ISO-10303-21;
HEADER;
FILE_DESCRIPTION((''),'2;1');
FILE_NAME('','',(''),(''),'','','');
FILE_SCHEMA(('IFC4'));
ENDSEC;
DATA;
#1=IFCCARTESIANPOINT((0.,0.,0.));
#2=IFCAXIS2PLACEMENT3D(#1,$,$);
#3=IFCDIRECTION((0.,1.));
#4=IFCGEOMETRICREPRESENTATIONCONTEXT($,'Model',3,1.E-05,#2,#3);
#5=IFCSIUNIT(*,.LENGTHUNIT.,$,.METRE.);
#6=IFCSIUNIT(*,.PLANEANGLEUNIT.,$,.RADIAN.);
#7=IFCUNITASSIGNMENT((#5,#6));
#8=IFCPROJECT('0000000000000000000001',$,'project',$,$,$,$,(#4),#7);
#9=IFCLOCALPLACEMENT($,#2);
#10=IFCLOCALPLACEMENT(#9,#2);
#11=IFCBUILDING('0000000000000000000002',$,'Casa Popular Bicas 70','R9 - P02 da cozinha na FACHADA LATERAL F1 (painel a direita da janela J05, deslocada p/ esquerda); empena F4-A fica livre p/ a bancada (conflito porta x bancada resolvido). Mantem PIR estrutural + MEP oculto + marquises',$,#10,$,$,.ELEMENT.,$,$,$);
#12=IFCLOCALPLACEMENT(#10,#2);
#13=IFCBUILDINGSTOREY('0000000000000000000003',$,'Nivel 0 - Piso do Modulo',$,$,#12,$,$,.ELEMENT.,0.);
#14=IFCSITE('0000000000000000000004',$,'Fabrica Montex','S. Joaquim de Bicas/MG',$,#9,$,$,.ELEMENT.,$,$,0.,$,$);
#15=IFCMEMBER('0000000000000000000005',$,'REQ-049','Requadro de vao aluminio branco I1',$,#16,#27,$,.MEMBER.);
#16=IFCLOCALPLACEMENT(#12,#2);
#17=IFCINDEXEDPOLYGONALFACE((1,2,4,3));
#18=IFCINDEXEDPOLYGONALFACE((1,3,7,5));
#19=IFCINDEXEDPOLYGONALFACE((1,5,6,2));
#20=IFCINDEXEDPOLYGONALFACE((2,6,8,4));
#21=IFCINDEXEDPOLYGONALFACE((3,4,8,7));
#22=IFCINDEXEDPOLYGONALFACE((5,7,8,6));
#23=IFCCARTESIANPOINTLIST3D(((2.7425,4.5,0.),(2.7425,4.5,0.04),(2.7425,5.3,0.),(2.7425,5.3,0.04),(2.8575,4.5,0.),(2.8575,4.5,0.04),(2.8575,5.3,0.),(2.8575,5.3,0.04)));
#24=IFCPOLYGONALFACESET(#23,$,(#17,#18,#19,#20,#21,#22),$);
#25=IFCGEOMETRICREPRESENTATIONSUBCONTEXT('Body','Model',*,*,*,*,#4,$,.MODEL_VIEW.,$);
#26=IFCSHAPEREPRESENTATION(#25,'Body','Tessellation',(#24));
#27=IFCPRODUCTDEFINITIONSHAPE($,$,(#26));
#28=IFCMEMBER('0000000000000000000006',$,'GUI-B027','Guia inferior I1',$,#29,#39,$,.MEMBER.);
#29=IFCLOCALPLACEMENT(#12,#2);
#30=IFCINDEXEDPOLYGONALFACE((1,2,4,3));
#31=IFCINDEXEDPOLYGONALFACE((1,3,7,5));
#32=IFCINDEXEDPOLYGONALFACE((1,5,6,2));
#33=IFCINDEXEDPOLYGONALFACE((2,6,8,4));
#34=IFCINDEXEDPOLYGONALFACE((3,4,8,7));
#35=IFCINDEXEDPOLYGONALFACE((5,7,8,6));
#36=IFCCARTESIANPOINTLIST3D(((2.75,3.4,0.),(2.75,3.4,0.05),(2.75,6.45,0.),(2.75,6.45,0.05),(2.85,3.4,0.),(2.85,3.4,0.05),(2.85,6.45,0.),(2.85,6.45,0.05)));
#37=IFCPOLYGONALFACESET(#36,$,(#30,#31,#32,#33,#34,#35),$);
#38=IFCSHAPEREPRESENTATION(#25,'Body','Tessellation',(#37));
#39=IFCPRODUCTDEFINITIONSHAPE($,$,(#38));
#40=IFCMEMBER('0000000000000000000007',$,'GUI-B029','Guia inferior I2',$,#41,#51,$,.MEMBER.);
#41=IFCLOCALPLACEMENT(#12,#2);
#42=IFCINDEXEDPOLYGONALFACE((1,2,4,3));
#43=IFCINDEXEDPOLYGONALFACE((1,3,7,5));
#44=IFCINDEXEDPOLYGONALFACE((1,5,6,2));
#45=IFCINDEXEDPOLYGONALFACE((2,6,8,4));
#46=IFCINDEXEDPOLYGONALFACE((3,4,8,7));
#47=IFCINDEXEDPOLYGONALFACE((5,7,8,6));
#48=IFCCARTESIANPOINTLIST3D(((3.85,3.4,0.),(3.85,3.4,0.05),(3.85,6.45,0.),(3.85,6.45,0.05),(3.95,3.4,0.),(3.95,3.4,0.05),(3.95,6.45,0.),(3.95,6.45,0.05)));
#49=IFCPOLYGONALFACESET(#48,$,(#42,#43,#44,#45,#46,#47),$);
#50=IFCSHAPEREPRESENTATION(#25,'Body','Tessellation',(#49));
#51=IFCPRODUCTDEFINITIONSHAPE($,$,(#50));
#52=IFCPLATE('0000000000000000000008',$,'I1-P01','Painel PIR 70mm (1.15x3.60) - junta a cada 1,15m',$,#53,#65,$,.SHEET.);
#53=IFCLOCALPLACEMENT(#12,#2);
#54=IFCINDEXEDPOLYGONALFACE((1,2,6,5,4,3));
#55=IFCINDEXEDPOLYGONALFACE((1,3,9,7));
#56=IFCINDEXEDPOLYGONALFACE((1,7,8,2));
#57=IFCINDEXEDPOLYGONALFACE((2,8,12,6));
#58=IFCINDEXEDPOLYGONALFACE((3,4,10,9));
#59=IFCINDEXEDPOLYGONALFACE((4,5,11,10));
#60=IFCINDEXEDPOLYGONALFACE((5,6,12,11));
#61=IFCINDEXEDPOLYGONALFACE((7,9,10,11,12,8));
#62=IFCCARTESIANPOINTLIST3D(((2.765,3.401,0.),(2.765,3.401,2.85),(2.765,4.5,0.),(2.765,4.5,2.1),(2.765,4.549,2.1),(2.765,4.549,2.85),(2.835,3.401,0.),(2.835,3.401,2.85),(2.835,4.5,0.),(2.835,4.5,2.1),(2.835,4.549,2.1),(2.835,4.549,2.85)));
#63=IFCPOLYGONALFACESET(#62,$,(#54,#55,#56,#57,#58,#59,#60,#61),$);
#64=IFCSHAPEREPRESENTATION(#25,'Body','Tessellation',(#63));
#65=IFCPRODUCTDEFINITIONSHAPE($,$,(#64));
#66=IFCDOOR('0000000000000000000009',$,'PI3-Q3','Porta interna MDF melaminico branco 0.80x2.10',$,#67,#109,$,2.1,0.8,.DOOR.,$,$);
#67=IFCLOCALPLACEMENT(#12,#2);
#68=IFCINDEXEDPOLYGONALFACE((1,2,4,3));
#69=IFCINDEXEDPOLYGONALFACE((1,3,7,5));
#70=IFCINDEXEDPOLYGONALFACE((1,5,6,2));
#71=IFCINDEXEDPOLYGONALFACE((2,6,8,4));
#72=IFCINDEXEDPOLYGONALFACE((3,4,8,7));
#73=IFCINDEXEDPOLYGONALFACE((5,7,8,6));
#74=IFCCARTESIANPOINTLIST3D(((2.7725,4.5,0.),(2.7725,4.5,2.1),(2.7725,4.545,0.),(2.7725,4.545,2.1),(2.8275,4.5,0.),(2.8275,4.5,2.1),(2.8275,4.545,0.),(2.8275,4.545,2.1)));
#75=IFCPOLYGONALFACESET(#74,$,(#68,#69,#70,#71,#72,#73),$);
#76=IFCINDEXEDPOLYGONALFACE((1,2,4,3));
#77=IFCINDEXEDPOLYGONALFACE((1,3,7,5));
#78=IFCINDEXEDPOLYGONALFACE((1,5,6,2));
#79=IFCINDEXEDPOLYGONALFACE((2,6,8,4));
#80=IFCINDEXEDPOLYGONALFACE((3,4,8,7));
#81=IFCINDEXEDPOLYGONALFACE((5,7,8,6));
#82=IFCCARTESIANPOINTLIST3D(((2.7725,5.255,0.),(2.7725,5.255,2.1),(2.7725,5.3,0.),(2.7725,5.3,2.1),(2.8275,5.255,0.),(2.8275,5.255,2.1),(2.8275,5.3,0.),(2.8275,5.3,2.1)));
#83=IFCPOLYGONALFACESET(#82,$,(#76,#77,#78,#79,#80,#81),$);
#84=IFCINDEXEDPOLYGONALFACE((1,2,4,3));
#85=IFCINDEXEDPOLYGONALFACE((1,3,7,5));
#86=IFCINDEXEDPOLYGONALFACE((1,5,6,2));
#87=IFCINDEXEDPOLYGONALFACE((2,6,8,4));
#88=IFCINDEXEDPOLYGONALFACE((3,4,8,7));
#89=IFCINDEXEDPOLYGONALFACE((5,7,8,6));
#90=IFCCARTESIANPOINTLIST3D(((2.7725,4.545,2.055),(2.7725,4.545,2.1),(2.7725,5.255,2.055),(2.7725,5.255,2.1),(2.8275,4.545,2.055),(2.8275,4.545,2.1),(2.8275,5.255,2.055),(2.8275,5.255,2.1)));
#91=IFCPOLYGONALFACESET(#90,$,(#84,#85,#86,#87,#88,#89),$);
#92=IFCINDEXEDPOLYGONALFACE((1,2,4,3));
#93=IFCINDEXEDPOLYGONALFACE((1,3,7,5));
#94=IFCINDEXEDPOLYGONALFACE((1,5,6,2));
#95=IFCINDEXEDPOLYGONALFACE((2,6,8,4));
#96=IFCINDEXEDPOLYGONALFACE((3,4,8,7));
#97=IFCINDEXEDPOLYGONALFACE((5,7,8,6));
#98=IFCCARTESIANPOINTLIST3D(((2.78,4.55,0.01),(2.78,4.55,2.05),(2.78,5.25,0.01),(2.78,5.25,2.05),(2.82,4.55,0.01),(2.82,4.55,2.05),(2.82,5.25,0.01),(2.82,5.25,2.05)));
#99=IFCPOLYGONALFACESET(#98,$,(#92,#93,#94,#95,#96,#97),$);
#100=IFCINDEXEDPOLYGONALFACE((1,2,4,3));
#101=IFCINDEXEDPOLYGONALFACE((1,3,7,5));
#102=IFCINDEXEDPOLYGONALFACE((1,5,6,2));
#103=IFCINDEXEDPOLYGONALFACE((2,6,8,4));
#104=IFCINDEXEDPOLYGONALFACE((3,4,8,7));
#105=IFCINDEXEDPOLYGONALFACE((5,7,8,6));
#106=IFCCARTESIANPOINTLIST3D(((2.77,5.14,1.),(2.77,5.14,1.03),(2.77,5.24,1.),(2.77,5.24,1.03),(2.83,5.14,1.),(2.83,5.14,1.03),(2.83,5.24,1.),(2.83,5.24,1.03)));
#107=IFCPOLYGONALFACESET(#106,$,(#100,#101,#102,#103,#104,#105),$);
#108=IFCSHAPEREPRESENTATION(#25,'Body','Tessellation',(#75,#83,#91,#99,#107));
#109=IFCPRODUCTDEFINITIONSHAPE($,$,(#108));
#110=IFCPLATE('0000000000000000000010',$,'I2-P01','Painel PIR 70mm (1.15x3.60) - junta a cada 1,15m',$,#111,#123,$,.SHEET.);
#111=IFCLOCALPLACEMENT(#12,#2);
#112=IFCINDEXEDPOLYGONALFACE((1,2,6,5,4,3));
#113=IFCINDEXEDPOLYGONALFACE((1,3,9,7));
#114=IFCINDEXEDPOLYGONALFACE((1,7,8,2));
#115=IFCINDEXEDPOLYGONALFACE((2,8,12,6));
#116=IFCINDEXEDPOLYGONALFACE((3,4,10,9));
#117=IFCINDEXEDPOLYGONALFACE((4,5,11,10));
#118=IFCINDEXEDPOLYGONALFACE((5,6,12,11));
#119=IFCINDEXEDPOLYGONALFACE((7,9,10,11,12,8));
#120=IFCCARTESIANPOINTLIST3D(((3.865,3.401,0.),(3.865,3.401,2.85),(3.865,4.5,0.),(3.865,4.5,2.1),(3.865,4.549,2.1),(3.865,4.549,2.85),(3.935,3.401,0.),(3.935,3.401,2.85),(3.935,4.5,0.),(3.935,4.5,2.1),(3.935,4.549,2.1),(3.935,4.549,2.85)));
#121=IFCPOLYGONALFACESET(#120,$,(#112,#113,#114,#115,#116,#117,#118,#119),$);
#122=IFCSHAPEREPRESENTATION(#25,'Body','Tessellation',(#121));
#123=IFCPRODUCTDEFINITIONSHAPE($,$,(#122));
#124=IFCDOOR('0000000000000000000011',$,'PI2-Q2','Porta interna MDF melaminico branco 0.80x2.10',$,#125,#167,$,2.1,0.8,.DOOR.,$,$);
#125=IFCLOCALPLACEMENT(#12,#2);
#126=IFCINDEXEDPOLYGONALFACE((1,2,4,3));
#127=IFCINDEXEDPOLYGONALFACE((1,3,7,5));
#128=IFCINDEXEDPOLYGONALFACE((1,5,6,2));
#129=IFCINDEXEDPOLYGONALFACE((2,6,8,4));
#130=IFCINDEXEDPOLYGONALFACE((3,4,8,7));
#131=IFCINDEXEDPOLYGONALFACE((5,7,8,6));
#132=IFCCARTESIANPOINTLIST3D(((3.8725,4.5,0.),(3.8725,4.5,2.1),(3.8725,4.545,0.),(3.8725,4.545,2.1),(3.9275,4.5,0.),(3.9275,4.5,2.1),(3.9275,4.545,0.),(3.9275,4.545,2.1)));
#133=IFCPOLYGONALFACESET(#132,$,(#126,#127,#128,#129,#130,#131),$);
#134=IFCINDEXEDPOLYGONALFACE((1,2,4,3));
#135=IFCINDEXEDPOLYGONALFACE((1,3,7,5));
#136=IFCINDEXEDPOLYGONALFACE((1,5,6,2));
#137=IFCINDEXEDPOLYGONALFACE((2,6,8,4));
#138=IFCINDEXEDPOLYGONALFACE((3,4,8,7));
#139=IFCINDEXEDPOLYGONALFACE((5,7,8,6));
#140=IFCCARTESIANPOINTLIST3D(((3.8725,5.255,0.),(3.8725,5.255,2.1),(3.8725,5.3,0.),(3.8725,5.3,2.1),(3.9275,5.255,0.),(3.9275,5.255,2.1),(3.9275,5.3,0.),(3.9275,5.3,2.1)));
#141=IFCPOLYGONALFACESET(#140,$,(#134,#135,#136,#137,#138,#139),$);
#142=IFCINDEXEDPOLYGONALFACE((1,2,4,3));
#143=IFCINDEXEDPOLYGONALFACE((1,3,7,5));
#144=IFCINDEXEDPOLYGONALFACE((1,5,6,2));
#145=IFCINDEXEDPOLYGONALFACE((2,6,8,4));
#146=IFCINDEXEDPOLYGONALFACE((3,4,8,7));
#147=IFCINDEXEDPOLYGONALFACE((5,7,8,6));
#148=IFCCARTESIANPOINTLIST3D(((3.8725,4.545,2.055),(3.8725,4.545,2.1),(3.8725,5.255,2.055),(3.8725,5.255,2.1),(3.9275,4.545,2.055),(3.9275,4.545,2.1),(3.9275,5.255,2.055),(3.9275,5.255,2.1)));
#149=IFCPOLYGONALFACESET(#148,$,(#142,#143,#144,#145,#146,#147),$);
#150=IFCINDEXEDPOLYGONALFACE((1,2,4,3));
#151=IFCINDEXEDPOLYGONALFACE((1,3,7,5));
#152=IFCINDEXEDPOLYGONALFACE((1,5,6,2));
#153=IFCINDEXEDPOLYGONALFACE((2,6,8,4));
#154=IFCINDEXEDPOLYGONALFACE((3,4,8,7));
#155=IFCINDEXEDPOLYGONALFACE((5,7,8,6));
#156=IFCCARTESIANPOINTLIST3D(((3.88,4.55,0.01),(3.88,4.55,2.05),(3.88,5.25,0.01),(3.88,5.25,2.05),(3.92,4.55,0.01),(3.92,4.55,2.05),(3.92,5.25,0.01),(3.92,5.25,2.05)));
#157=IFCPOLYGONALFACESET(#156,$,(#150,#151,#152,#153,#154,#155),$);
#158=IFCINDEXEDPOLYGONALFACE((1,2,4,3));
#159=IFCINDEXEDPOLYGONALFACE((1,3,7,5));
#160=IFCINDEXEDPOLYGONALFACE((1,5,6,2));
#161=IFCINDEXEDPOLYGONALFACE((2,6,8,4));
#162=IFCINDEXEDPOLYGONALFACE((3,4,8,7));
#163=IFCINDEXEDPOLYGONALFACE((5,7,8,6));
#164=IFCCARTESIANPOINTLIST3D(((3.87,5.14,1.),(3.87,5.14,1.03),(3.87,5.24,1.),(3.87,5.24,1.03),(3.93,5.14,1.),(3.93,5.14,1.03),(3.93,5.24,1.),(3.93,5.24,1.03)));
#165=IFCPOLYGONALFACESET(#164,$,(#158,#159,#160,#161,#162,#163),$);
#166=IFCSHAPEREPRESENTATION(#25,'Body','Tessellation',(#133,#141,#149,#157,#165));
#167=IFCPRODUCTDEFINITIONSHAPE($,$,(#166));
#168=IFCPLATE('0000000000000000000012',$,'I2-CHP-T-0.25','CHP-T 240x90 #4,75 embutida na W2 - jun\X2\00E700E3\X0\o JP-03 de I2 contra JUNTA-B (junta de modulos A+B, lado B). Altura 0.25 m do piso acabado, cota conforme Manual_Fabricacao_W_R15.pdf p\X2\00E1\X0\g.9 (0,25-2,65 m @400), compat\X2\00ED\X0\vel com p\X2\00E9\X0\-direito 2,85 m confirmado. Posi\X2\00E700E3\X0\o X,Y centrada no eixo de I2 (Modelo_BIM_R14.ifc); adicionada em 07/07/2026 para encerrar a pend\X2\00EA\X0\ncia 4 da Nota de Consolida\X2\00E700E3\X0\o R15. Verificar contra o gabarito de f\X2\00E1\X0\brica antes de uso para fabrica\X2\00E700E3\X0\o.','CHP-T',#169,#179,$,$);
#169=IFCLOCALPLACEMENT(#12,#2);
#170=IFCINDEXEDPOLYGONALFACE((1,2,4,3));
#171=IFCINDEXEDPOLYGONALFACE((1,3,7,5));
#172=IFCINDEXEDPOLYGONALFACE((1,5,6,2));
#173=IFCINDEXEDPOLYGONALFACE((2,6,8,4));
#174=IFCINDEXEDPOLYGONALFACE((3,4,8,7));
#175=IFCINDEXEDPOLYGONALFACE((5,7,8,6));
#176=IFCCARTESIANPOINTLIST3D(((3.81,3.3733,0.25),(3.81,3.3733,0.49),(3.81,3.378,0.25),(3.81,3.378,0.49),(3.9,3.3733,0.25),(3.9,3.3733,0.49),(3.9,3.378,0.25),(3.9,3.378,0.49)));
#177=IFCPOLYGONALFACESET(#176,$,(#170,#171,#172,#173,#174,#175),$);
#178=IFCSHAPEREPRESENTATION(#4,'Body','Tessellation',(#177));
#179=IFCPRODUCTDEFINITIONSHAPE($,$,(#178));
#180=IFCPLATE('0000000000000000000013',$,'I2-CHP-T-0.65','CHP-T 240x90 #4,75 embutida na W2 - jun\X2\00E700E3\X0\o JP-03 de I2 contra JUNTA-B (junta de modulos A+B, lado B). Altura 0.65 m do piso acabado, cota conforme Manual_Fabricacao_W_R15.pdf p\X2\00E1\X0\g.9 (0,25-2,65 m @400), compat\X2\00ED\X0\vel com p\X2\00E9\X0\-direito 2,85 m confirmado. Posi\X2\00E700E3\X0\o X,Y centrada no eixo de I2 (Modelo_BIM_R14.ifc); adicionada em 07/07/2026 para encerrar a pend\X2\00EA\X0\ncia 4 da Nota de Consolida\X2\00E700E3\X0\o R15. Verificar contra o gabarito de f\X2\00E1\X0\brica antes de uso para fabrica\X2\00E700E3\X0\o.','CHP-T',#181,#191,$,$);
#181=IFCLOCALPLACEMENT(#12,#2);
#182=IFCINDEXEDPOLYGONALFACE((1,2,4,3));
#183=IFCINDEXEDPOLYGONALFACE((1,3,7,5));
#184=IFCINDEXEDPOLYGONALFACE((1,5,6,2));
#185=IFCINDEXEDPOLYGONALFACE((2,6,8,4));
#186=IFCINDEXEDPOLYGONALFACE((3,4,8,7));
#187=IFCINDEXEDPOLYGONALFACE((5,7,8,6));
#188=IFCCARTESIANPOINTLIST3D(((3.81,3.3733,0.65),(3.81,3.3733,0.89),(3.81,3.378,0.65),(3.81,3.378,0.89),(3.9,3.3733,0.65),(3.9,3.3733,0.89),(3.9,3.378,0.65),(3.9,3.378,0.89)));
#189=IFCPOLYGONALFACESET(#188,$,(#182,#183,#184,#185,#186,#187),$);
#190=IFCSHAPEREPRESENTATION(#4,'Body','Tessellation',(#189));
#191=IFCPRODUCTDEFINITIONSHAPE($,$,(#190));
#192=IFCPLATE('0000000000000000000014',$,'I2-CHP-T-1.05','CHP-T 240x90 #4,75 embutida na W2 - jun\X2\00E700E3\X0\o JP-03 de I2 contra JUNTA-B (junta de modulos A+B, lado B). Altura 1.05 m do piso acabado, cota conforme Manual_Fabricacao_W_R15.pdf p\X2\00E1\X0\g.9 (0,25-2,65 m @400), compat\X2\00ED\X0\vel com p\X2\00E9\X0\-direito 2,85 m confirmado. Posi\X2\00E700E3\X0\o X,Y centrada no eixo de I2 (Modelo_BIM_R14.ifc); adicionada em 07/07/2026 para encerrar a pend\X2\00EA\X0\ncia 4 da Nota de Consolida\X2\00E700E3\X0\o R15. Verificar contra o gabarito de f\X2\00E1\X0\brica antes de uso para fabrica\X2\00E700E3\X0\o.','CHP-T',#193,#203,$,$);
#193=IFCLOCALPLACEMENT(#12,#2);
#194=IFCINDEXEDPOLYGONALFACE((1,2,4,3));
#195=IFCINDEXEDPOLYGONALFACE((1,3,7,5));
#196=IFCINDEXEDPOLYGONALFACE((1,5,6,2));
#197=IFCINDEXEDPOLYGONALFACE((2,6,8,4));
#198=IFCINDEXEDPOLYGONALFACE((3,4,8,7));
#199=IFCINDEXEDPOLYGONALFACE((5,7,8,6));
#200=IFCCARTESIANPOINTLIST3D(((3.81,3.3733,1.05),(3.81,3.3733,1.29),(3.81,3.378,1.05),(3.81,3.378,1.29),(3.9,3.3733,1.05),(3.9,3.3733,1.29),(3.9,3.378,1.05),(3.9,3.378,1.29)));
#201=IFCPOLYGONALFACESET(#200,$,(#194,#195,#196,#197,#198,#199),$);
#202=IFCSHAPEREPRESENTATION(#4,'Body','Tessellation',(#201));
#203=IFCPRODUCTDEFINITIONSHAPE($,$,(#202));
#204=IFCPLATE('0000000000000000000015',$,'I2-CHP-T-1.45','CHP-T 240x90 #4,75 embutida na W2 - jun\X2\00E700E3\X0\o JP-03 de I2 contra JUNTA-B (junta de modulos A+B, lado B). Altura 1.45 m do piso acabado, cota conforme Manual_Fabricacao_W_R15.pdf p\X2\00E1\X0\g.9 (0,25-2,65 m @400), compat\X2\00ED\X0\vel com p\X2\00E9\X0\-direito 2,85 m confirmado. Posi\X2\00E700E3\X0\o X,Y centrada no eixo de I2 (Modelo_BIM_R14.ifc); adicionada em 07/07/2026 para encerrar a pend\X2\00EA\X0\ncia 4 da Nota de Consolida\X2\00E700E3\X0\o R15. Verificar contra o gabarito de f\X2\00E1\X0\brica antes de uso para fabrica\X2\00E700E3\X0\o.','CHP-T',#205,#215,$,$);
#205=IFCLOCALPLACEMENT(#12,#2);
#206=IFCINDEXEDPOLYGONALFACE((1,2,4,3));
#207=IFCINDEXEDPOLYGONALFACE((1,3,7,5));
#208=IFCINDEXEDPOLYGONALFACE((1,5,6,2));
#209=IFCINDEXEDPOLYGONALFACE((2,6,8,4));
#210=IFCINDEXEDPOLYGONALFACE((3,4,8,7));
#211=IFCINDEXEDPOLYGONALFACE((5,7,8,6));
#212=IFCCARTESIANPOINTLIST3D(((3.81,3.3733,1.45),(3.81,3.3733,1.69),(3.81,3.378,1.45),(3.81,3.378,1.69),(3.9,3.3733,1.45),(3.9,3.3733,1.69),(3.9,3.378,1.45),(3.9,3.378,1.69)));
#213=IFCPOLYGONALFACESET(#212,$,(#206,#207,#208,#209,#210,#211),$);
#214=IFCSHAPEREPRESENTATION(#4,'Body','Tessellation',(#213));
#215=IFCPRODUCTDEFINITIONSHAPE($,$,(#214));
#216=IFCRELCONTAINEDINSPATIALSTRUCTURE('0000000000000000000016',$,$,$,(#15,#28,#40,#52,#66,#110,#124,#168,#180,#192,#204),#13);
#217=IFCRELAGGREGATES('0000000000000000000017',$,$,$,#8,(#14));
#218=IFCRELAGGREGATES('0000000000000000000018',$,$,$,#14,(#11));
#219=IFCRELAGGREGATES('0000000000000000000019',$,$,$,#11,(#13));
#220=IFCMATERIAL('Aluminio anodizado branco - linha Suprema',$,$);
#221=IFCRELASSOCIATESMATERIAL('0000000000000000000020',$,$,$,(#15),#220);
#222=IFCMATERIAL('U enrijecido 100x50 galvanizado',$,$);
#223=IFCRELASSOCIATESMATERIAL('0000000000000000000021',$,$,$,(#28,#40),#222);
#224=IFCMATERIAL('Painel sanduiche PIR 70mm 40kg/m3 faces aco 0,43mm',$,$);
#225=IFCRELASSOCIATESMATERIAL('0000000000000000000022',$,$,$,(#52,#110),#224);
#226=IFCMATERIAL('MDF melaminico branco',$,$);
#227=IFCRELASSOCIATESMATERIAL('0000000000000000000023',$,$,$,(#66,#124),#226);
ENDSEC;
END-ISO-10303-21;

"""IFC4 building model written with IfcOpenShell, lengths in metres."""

from ifc_helpers import new_model, si_unit, direction, frame, frame_2d, origin, origin_with_axes, origin_2d, place, context, subcontext, project, spatial, rectangle, extrude, material, element, fill, save


model = new_model("IFC4")

# Units and contexts
model_context = context("Model", 3, precision=1e-05, world=origin(), true_north=direction((0.0, 1.0)))
body_context = subcontext(model_context, "Body", "Model", "MODEL_VIEW")
ifc_project = project(units=[si_unit("LENGTHUNIT", "METRE"), si_unit("PLANEANGLEUNIT", "RADIAN")], contexts=[model_context])

# Site, building, storey
site_placement = place(None, origin())
site = spatial("IfcSite", under=ifc_project, at=site_placement, Name="Fabrica Montex", Description="S. Joaquim de Bicas/MG", CompositionType="ELEMENT", RefElevation=0.0)
building_placement = place(site_placement, origin())
building = spatial("IfcBuilding", under=site, at=building_placement, Name="Casa Popular Bicas 70", Description="R9 - P02 da cozinha na FACHADA LATERAL F1 (painel a direita da janela J05, deslocada p/ esquerda); empena F4-A fica livre p/ a bancada (conflito porta x bancada resolvido). Mantem PIR estrutural + MEP oculto + marquises", CompositionType="ELEMENT")
storey_placement = place(building_placement, origin())
storey = spatial("IfcBuildingStorey", under=building, at=storey_placement, Name="Nivel 0 - Piso do Modulo", CompositionType="ELEMENT", Elevation=0.0)

# Members
ifc_material_1 = material(Name="Aluminio anodizado branco - linha Suprema")
member_placement = place(storey_placement, frame((2.8, 4.5, 0.02), z_axis=(0.0, 1.0, 0.0), x_axis=(0.0, 0.0, 1.0)))
element("IfcMember", 1, at=member_placement, inside=storey, material=ifc_material_1, Name="REQ-049", Description="Requadro de vao aluminio branco I1", PredefinedType="MEMBER", context=body_context, shape_type="SweptSolid", body=[
    extrude(rectangle(XDim=0.04, YDim=0.115, at=origin_2d()), origin(), (0.0, 0.0, 1.0), 0.8),
])
ifc_material_2 = material(Name="U enrijecido 100x50 galvanizado")
for number, where, z_axis, x_axis, name, description in (
    (2, (2.8, 3.4, 0.025), (0.0, 1.0, 0.0), (0.0, 0.0, 1.0), "GUI-B027", "Guia inferior I1"),
    (3, (3.9, 3.4, 0.025), (0.0, 1.0, 0.0), (0.0, 0.0, 1.0), "GUI-B029", "Guia inferior I2"),
):
    element("IfcMember", number, at=place(storey_placement, frame(where, z_axis=z_axis, x_axis=x_axis)), inside=storey, material=ifc_material_2, Name=name, Description=description, PredefinedType="MEMBER", context=body_context, shape_type="SweptSolid", body=[
        extrude(rectangle(XDim=0.05, YDim=0.1, at=origin_2d()), origin(), (0.0, 0.0, 1.0), 3.05),
    ])

# Shared definitions
ifc_material_3 = material(Name="Painel sanduiche PIR 70mm 40kg/m3 faces aco 0,43mm")

# Plates, openings, doors
plate_1_placement = place(storey_placement, frame((2.8, 3.401, 0.0), x_axis=(0.0, 1.0, 0.0)))
plate_1 = element("IfcPlate", 4, at=plate_1_placement, inside=storey, material=ifc_material_3, Name="I1-P01", Description="Painel PIR 70mm (1.15x3.60) - junta a cada 1,15m", PredefinedType="SHEET", context=body_context, shape_type="SweptSolid", body=[
    extrude(rectangle(XDim=1.148, YDim=0.07, at=frame_2d((0.574, 0.0))), origin(), (0.0, 0.0, 1.0), 2.85),
])
opening_1_placement = place(storey_placement, frame((2.8, 4.525, 0.0)))
opening_1 = element("IfcOpeningElement", 5, at=opening_1_placement, cuts=plate_1, PredefinedType="OPENING", context=body_context, shape_type="SweptSolid", body=[
    extrude(rectangle(XDim=0.1, YDim=0.05, at=origin_2d()), origin(), (0.0, 0.0, 1.0), 2.1),
])
ifc_material_4 = material(Name="MDF melaminico branco")
door_1_placement = place(storey_placement, frame((2.8, 4.5, 0.0), x_axis=(0.0, 1.0, 0.0)))
door_1 = element("IfcDoor", 6, at=door_1_placement, inside=storey, material=ifc_material_4, Name="PI3-Q3", Description="Porta interna MDF melaminico branco 0.80x2.10", OverallHeight=2.1, OverallWidth=0.8, PredefinedType="DOOR", context=body_context, shape_type="SweptSolid", body=[
    extrude(rectangle(XDim=0.045, YDim=0.055, at=frame_2d((0.0225, 0.0))), origin(), (0.0, 0.0, 1.0), 2.1),
    extrude(rectangle(XDim=0.045, YDim=0.055, at=frame_2d((0.7775, 0.0))), origin(), (0.0, 0.0, 1.0), 2.1),
    extrude(rectangle(XDim=0.71, YDim=0.055, at=frame_2d((0.4, 0.0))), frame((0.0, 0.0, 2.055)), (0.0, 0.0, 1.0), 0.045),
    extrude(rectangle(XDim=0.7, YDim=0.04, at=frame_2d((0.4, 0.0))), frame((0.0, 0.0, 0.01)), (0.0, 0.0, 1.0), 2.04),
    extrude(rectangle(XDim=0.1, YDim=0.06, at=frame_2d((0.69, 0.0))), frame((0.0, 0.0, 1.0)), (0.0, 0.0, 1.0), 0.03),
])
fill(opening_1, door_1)
plate_2_placement = place(storey_placement, frame((3.9, 3.401, 0.0), x_axis=(0.0, 1.0, 0.0)))
plate_2 = element("IfcPlate", 7, at=plate_2_placement, inside=storey, material=ifc_material_3, Name="I2-P01", Description="Painel PIR 70mm (1.15x3.60) - junta a cada 1,15m", PredefinedType="SHEET", context=body_context, shape_type="SweptSolid", body=[
    extrude(rectangle(XDim=1.148, YDim=0.07, at=frame_2d((0.574, 0.0))), origin(), (0.0, 0.0, 1.0), 2.85),
])
opening_2_placement = place(storey_placement, frame((3.9, 4.525, 0.0)))
opening_2 = element("IfcOpeningElement", 8, at=opening_2_placement, cuts=plate_2, PredefinedType="OPENING", context=body_context, shape_type="SweptSolid", body=[
    extrude(rectangle(XDim=0.1, YDim=0.05, at=origin_2d()), origin(), (0.0, 0.0, 1.0), 2.1),
])
door_2_placement = place(storey_placement, frame((3.9, 4.5, 0.0), x_axis=(0.0, 1.0, 0.0)))
door_2 = element("IfcDoor", 9, at=door_2_placement, inside=storey, material=ifc_material_4, Name="PI2-Q2", Description="Porta interna MDF melaminico branco 0.80x2.10", OverallHeight=2.1, OverallWidth=0.8, PredefinedType="DOOR", context=body_context, shape_type="SweptSolid", body=[
    extrude(rectangle(XDim=0.045, YDim=0.055, at=frame_2d((0.0225, 0.0))), origin(), (0.0, 0.0, 1.0), 2.1),
    extrude(rectangle(XDim=0.045, YDim=0.055, at=frame_2d((0.7775, 0.0))), origin(), (0.0, 0.0, 1.0), 2.1),
    extrude(rectangle(XDim=0.71, YDim=0.055, at=frame_2d((0.4, 0.0))), frame((0.0, 0.0, 2.055)), (0.0, 0.0, 1.0), 0.045),
    extrude(rectangle(XDim=0.7, YDim=0.04, at=frame_2d((0.4, 0.0))), frame((0.0, 0.0, 0.01)), (0.0, 0.0, 1.0), 2.04),
    extrude(rectangle(XDim=0.1, YDim=0.06, at=frame_2d((0.69, 0.0))), frame((0.0, 0.0, 1.0)), (0.0, 0.0, 1.0), 0.03),
])
fill(opening_2, door_2)

# Plates
for number, where, z_axis, x_axis, name, description in (
    (10, (3.855, 3.3756, 0.25), (0.0, 0.0, 1.0), (1.0, 0.0, 0.0), "I2-CHP-T-0.25", "CHP-T 240x90 #4,75 embutida na W2 - junção JP-03 de I2 contra JUNTA-B (junta de modulos A+B, lado B). Altura 0.25 m do piso acabado, cota conforme Manual_Fabricacao_W_R15.pdf pág.9 (0,25-2,65 m @400), compatível com pé-direito 2,85 m confirmado. Posição X,Y centrada no eixo de I2 (Modelo_BIM_R14.ifc); adicionada em 07/07/2026 para encerrar a pendência 4 da Nota de Consolidação R15. Verificar contra o gabarito de fábrica antes de uso para fabricação."),
    (11, (3.855, 3.3756, 0.65), (0.0, 0.0, 1.0), (1.0, 0.0, 0.0), "I2-CHP-T-0.65", "CHP-T 240x90 #4,75 embutida na W2 - junção JP-03 de I2 contra JUNTA-B (junta de modulos A+B, lado B). Altura 0.65 m do piso acabado, cota conforme Manual_Fabricacao_W_R15.pdf pág.9 (0,25-2,65 m @400), compatível com pé-direito 2,85 m confirmado. Posição X,Y centrada no eixo de I2 (Modelo_BIM_R14.ifc); adicionada em 07/07/2026 para encerrar a pendência 4 da Nota de Consolidação R15. Verificar contra o gabarito de fábrica antes de uso para fabricação."),
    (12, (3.855, 3.3756, 1.05), (0.0, 0.0, 1.0), (1.0, 0.0, 0.0), "I2-CHP-T-1.05", "CHP-T 240x90 #4,75 embutida na W2 - junção JP-03 de I2 contra JUNTA-B (junta de modulos A+B, lado B). Altura 1.05 m do piso acabado, cota conforme Manual_Fabricacao_W_R15.pdf pág.9 (0,25-2,65 m @400), compatível com pé-direito 2,85 m confirmado. Posição X,Y centrada no eixo de I2 (Modelo_BIM_R14.ifc); adicionada em 07/07/2026 para encerrar a pendência 4 da Nota de Consolidação R15. Verificar contra o gabarito de fábrica antes de uso para fabricação."),
    (13, (3.855, 3.3756, 1.45), (0.0, 0.0, 1.0), (1.0, 0.0, 0.0), "I2-CHP-T-1.45", "CHP-T 240x90 #4,75 embutida na W2 - junção JP-03 de I2 contra JUNTA-B (junta de modulos A+B, lado B). Altura 1.45 m do piso acabado, cota conforme Manual_Fabricacao_W_R15.pdf pág.9 (0,25-2,65 m @400), compatível com pé-direito 2,85 m confirmado. Posição X,Y centrada no eixo de I2 (Modelo_BIM_R14.ifc); adicionada em 07/07/2026 para encerrar a pendência 4 da Nota de Consolidação R15. Verificar contra o gabarito de fábrica antes de uso para fabricação."),
):
    element("IfcPlate", number, at=place(storey_placement, frame(where, z_axis=z_axis, x_axis=x_axis)), inside=storey, Name=name, Description=description, ObjectType="CHP-T", context=model_context, shape_type="SweptSolid", body=[
        extrude(rectangle(XDim=0.09, YDim=0.0047, at=origin_2d()), origin_with_axes(), (0.0, 0.0, 1.0), 0.24),
    ])

save(model, "model.ifc")
